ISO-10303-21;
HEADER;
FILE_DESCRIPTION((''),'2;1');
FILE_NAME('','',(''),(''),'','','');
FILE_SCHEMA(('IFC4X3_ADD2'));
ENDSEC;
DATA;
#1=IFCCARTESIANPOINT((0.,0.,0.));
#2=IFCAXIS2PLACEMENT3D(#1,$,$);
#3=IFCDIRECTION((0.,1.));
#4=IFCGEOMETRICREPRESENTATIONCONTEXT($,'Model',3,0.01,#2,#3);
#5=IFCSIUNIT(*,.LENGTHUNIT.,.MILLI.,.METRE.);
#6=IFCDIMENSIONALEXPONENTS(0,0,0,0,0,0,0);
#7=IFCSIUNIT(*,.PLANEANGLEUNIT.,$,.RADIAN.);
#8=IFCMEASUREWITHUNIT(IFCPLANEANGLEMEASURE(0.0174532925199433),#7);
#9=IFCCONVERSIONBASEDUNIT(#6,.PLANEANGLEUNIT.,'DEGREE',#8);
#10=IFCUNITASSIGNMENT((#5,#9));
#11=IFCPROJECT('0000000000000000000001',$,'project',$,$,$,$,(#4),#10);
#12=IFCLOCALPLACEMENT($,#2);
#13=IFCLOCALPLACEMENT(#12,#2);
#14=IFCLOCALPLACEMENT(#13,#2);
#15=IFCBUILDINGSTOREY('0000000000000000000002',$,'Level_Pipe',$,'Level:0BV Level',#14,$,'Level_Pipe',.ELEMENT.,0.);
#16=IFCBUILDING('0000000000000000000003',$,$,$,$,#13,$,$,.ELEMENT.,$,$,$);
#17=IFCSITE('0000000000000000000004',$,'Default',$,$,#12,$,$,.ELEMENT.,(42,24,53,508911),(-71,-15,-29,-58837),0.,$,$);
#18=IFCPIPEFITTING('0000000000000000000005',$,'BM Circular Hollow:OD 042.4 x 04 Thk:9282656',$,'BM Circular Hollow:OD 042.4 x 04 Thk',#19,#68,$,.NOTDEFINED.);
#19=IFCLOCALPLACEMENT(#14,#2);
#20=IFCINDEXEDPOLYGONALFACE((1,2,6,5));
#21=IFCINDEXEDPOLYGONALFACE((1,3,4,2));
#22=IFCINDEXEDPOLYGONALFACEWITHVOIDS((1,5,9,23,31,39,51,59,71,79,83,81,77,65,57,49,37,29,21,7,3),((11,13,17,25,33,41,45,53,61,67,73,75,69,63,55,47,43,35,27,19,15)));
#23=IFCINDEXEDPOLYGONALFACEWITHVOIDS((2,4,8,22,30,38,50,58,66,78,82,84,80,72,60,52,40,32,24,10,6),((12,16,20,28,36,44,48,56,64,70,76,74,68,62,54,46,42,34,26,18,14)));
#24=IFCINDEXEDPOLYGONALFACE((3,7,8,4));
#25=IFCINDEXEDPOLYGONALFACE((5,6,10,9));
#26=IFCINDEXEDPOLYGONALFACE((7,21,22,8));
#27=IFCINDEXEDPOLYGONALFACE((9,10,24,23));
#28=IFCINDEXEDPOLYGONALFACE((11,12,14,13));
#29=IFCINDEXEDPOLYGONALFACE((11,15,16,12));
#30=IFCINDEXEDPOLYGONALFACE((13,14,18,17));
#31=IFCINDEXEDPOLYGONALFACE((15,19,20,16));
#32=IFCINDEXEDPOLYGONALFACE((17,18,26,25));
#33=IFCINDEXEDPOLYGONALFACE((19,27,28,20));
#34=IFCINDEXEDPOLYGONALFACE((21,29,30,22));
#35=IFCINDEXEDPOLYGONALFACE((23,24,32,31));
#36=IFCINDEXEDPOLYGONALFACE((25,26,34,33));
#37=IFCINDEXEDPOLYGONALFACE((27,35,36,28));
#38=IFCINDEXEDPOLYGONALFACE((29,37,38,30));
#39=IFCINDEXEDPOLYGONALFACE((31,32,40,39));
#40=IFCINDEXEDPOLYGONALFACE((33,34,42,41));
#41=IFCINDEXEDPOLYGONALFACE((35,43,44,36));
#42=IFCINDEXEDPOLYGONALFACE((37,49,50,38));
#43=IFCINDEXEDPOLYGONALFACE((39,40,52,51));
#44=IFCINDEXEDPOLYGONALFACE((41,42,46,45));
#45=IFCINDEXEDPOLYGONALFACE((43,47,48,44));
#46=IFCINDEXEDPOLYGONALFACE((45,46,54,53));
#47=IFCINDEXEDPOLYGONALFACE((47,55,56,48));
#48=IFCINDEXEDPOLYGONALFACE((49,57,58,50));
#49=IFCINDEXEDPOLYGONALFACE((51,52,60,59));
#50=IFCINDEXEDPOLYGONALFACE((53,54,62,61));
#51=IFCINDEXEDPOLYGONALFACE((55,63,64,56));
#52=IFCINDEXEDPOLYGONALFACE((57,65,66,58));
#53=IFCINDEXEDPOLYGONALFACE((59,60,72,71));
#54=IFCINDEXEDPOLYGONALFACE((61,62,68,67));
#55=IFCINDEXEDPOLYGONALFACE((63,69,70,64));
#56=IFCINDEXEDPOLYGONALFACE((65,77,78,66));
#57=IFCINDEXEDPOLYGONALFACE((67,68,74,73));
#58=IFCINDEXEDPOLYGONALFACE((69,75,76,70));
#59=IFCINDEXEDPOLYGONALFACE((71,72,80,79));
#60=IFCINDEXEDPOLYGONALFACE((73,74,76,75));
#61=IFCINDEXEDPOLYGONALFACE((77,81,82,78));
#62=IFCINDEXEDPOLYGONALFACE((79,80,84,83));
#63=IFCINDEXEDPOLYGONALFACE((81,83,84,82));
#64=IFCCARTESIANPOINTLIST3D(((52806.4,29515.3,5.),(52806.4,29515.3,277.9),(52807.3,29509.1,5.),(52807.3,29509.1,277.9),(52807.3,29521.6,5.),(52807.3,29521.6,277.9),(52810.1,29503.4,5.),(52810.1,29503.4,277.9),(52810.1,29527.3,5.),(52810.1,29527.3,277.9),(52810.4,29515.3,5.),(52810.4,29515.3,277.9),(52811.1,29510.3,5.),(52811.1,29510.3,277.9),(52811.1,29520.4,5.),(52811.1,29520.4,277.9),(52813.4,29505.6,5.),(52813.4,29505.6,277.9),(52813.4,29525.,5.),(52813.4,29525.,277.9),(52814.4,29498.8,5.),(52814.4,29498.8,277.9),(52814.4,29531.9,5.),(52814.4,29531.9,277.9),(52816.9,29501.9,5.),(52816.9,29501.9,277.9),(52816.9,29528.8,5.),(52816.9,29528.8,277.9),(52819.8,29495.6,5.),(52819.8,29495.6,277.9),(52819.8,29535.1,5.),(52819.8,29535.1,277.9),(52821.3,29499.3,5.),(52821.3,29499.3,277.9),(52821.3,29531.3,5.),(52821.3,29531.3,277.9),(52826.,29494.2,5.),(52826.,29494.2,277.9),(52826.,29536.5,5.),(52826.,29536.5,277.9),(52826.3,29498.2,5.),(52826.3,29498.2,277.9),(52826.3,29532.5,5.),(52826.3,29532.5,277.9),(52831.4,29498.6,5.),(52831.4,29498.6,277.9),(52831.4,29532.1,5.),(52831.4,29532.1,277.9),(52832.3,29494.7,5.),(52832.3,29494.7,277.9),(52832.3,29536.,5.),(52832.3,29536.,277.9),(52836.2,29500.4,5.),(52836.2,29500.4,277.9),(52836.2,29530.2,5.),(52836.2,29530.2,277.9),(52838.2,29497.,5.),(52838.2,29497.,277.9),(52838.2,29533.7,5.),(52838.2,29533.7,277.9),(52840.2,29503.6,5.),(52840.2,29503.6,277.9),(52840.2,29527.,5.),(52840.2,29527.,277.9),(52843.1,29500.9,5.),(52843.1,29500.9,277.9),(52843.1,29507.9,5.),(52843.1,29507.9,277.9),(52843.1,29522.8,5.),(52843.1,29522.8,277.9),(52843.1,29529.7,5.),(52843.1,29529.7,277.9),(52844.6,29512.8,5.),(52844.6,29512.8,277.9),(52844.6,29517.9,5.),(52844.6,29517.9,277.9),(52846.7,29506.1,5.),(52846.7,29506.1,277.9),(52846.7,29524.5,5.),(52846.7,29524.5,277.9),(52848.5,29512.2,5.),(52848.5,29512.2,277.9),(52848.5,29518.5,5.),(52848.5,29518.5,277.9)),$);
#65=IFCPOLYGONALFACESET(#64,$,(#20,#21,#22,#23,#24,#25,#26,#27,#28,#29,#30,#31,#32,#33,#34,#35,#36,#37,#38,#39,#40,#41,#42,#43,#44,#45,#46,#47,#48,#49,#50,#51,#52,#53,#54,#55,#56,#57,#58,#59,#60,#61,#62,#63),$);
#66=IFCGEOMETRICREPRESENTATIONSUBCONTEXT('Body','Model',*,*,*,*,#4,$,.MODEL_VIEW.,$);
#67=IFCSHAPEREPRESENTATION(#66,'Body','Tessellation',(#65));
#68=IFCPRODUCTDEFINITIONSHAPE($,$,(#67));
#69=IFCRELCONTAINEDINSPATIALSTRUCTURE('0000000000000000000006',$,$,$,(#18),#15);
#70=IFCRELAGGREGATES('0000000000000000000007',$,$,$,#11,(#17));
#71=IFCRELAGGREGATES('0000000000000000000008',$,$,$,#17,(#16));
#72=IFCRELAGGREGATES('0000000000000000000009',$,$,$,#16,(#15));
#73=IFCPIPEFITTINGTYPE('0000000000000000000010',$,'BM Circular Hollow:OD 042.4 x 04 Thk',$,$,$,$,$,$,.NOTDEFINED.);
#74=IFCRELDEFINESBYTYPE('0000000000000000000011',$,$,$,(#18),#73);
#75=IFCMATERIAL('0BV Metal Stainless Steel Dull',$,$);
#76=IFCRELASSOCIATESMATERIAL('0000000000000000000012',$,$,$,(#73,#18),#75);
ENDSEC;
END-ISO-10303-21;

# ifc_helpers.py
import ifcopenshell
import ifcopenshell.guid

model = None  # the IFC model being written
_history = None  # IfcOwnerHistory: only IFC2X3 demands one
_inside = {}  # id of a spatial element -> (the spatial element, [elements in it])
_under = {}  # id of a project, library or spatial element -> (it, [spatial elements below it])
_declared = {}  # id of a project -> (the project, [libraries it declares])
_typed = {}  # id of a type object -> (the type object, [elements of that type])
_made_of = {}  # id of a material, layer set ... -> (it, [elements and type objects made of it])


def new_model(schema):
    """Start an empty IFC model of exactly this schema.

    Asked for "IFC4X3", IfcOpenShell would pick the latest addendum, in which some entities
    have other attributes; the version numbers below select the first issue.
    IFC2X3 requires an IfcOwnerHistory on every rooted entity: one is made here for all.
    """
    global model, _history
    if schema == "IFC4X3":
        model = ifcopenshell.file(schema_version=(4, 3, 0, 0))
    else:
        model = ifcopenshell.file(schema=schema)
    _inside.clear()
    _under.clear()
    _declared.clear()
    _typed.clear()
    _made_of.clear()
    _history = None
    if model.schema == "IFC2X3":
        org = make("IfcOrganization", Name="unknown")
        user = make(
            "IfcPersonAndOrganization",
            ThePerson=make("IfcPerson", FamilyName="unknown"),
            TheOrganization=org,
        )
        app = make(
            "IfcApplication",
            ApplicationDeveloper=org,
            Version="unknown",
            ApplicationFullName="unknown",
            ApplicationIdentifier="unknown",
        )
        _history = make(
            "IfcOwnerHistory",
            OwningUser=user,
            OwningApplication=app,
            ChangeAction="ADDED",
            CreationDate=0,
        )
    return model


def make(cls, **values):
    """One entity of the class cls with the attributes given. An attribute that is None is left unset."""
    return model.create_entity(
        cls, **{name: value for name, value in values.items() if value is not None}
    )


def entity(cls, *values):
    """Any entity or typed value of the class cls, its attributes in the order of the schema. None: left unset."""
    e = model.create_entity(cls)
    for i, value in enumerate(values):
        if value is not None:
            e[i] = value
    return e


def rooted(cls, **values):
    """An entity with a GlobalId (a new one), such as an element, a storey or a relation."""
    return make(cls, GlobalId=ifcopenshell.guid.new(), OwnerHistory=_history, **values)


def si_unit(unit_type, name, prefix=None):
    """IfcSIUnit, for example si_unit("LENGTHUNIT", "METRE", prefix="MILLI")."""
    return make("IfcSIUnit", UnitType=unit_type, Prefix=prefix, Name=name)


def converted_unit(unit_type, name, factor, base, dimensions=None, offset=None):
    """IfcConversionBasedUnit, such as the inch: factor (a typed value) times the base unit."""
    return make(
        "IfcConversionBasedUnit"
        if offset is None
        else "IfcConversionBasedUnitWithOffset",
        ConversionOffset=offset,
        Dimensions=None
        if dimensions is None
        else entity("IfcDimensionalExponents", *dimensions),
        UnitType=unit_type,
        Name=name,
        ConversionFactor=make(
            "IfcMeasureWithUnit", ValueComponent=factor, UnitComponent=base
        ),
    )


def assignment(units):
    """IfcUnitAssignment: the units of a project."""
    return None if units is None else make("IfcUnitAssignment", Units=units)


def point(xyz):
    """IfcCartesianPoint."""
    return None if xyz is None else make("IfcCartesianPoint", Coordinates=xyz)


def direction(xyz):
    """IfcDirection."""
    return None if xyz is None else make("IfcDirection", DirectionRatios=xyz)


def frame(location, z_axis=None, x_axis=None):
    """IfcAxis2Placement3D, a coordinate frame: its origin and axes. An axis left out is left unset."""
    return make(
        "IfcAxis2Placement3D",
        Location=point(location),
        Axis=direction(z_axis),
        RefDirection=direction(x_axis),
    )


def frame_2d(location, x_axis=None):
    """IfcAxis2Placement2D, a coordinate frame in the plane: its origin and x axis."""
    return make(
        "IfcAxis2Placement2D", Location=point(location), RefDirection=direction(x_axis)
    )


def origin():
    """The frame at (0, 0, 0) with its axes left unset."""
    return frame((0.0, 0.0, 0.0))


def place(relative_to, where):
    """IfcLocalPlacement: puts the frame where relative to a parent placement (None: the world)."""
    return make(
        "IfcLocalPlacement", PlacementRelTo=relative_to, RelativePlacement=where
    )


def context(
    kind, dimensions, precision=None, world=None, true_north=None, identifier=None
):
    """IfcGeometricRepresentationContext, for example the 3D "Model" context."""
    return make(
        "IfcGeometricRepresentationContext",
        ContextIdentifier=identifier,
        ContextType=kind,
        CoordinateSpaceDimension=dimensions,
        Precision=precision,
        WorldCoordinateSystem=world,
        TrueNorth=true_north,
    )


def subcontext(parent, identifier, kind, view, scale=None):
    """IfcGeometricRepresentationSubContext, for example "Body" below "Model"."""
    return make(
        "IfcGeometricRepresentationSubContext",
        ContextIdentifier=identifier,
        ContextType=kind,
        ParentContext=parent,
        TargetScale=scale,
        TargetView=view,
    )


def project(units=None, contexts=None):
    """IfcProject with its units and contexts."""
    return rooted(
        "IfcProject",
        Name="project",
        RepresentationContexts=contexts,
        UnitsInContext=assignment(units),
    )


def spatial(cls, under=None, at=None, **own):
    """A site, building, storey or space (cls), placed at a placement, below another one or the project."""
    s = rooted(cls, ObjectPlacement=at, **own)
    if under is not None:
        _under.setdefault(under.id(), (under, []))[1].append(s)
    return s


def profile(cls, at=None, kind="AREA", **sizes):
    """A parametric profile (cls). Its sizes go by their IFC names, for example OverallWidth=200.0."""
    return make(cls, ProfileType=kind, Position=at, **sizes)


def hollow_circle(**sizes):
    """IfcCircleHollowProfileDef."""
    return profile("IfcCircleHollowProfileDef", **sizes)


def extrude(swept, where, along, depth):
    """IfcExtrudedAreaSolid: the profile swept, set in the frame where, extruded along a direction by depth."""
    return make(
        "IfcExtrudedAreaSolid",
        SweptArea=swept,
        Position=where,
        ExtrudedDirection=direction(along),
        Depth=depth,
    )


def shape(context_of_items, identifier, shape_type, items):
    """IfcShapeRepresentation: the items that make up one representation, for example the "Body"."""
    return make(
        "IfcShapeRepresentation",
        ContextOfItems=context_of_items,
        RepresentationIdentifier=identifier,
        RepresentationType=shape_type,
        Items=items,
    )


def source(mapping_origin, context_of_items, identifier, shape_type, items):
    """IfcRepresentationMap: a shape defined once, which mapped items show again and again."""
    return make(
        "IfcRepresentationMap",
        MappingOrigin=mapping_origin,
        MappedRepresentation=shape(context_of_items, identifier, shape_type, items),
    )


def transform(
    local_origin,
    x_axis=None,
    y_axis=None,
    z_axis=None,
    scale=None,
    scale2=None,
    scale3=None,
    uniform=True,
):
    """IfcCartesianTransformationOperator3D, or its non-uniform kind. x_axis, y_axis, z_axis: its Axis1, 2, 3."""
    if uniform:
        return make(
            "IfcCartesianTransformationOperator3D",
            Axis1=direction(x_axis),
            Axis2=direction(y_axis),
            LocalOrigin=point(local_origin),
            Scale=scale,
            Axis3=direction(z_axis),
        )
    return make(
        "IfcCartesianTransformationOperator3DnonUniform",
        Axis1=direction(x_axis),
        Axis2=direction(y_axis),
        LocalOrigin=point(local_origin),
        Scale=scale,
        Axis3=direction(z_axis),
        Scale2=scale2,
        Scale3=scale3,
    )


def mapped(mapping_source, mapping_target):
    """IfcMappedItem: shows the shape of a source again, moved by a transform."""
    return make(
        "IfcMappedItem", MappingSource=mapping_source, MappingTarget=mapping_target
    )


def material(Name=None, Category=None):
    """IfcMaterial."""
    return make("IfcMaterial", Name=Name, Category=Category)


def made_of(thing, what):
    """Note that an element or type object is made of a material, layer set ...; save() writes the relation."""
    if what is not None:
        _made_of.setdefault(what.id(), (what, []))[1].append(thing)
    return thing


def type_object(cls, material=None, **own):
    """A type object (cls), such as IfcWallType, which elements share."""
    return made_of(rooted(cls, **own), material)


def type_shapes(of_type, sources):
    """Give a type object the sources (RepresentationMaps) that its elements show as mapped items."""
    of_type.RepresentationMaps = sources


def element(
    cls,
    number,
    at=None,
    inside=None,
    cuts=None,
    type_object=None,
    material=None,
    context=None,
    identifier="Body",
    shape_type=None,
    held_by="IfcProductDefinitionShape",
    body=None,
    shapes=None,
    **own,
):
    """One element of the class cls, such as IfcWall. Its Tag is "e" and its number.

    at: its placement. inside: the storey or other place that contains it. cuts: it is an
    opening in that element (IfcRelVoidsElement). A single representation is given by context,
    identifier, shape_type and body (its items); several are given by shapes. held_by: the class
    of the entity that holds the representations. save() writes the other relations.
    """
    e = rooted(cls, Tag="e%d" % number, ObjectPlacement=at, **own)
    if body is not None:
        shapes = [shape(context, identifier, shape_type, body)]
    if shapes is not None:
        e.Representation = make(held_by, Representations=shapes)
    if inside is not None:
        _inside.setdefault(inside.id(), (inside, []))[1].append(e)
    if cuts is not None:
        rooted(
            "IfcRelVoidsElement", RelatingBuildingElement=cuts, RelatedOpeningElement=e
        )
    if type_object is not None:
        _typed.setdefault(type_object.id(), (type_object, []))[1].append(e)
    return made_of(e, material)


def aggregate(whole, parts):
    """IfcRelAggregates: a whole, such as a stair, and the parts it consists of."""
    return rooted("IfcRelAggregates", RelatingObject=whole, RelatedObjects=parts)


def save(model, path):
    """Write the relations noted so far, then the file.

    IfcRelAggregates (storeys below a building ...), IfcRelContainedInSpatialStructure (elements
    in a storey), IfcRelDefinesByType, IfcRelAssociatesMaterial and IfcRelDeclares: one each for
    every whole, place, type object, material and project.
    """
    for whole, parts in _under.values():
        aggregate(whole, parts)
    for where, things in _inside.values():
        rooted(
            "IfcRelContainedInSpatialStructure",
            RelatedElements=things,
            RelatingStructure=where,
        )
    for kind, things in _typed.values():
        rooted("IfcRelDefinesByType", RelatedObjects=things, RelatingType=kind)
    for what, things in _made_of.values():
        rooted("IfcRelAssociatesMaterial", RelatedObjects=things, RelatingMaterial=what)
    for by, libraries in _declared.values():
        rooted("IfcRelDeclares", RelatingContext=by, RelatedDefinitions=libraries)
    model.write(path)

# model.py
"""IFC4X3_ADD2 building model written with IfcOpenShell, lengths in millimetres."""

from ifc_helpers import new_model, entity, si_unit, converted_unit, direction, frame, frame_2d, origin, place, context, subcontext, project, spatial, hollow_circle, extrude, source, transform, mapped, material, type_object, type_shapes, element, save


model = new_model("IFC4X3_ADD2")

# Units and contexts
model_context = context("Model", 3, precision=0.01, world=origin(), true_north=direction((0.0, 1.0)))
body_context = subcontext(model_context, "Body", "Model", "MODEL_VIEW")
ifc_project = project(units=[si_unit("LENGTHUNIT", "METRE", prefix="MILLI"), converted_unit("PLANEANGLEUNIT", "DEGREE", entity("IfcPlaneAngleMeasure", 0.0174532925199433), si_unit("PLANEANGLEUNIT", "RADIAN"), dimensions=[0, 0, 0, 0, 0, 0, 0])], contexts=[model_context])

# Site, building, storey
site_placement = place(None, origin())
site = spatial("IfcSite", under=ifc_project, at=site_placement, Name="Default", CompositionType="ELEMENT", RefLatitude=(42, 24, 53, 508911), RefLongitude=(-71, -15, -29, -58837), RefElevation=0.0)
building_placement = place(site_placement, origin())
building = spatial("IfcBuilding", under=site, at=building_placement, CompositionType="ELEMENT")
storey_placement = place(building_placement, origin())
storey = spatial("IfcBuildingStorey", under=building, at=storey_placement, Name="Level_Pipe", ObjectType="Level:0BV Level", LongName="Level_Pipe", CompositionType="ELEMENT", Elevation=0.0)

# Shared definitions
ifc_material_1 = material(Name="0BV Metal Stainless Steel Dull")

# Pipe fitting
pipe_fitting_type_1 = type_object("IfcPipeFittingType", Name="BM Circular Hollow:OD 042.4 x 04 Thk", PredefinedType="NOTDEFINED", material=ifc_material_1)
shared_shape_1 = source(origin(), body_context, "Body", "SweptSolid", [
    extrude(hollow_circle(Radius=21.2, WallThickness=4.0, at=frame_2d((0.0, 0.0), x_axis=(1.0, 0.0))), frame((-136.5, 0.0, 0.0), z_axis=(1.0, 0.0, 0.0), x_axis=(0.0, -1.0, 0.0)), (0.0, 0.0, 1.0), 272.9),
])
type_shapes(pipe_fitting_type_1, [shared_shape_1])
pipe_fitting_1_placement = place(storey_placement, frame((52827.6, 29515.3, 141.5), z_axis=(0.0, 1.0, 0.0), x_axis=(0.0, 0.0, 1.0)))
element("IfcPipeFitting", 1, at=pipe_fitting_1_placement, inside=storey, type_object=pipe_fitting_type_1, material=ifc_material_1, Name="BM Circular Hollow:OD 042.4 x 04 Thk:9282656", ObjectType="BM Circular Hollow:OD 042.4 x 04 Thk", PredefinedType="NOTDEFINED", context=body_context, shape_type="MappedRepresentation", body=[
    mapped(shared_shape_1, transform((0.0, 0.0, 0.0), scale=1.0)),
])

save(model, "model.ifc")
